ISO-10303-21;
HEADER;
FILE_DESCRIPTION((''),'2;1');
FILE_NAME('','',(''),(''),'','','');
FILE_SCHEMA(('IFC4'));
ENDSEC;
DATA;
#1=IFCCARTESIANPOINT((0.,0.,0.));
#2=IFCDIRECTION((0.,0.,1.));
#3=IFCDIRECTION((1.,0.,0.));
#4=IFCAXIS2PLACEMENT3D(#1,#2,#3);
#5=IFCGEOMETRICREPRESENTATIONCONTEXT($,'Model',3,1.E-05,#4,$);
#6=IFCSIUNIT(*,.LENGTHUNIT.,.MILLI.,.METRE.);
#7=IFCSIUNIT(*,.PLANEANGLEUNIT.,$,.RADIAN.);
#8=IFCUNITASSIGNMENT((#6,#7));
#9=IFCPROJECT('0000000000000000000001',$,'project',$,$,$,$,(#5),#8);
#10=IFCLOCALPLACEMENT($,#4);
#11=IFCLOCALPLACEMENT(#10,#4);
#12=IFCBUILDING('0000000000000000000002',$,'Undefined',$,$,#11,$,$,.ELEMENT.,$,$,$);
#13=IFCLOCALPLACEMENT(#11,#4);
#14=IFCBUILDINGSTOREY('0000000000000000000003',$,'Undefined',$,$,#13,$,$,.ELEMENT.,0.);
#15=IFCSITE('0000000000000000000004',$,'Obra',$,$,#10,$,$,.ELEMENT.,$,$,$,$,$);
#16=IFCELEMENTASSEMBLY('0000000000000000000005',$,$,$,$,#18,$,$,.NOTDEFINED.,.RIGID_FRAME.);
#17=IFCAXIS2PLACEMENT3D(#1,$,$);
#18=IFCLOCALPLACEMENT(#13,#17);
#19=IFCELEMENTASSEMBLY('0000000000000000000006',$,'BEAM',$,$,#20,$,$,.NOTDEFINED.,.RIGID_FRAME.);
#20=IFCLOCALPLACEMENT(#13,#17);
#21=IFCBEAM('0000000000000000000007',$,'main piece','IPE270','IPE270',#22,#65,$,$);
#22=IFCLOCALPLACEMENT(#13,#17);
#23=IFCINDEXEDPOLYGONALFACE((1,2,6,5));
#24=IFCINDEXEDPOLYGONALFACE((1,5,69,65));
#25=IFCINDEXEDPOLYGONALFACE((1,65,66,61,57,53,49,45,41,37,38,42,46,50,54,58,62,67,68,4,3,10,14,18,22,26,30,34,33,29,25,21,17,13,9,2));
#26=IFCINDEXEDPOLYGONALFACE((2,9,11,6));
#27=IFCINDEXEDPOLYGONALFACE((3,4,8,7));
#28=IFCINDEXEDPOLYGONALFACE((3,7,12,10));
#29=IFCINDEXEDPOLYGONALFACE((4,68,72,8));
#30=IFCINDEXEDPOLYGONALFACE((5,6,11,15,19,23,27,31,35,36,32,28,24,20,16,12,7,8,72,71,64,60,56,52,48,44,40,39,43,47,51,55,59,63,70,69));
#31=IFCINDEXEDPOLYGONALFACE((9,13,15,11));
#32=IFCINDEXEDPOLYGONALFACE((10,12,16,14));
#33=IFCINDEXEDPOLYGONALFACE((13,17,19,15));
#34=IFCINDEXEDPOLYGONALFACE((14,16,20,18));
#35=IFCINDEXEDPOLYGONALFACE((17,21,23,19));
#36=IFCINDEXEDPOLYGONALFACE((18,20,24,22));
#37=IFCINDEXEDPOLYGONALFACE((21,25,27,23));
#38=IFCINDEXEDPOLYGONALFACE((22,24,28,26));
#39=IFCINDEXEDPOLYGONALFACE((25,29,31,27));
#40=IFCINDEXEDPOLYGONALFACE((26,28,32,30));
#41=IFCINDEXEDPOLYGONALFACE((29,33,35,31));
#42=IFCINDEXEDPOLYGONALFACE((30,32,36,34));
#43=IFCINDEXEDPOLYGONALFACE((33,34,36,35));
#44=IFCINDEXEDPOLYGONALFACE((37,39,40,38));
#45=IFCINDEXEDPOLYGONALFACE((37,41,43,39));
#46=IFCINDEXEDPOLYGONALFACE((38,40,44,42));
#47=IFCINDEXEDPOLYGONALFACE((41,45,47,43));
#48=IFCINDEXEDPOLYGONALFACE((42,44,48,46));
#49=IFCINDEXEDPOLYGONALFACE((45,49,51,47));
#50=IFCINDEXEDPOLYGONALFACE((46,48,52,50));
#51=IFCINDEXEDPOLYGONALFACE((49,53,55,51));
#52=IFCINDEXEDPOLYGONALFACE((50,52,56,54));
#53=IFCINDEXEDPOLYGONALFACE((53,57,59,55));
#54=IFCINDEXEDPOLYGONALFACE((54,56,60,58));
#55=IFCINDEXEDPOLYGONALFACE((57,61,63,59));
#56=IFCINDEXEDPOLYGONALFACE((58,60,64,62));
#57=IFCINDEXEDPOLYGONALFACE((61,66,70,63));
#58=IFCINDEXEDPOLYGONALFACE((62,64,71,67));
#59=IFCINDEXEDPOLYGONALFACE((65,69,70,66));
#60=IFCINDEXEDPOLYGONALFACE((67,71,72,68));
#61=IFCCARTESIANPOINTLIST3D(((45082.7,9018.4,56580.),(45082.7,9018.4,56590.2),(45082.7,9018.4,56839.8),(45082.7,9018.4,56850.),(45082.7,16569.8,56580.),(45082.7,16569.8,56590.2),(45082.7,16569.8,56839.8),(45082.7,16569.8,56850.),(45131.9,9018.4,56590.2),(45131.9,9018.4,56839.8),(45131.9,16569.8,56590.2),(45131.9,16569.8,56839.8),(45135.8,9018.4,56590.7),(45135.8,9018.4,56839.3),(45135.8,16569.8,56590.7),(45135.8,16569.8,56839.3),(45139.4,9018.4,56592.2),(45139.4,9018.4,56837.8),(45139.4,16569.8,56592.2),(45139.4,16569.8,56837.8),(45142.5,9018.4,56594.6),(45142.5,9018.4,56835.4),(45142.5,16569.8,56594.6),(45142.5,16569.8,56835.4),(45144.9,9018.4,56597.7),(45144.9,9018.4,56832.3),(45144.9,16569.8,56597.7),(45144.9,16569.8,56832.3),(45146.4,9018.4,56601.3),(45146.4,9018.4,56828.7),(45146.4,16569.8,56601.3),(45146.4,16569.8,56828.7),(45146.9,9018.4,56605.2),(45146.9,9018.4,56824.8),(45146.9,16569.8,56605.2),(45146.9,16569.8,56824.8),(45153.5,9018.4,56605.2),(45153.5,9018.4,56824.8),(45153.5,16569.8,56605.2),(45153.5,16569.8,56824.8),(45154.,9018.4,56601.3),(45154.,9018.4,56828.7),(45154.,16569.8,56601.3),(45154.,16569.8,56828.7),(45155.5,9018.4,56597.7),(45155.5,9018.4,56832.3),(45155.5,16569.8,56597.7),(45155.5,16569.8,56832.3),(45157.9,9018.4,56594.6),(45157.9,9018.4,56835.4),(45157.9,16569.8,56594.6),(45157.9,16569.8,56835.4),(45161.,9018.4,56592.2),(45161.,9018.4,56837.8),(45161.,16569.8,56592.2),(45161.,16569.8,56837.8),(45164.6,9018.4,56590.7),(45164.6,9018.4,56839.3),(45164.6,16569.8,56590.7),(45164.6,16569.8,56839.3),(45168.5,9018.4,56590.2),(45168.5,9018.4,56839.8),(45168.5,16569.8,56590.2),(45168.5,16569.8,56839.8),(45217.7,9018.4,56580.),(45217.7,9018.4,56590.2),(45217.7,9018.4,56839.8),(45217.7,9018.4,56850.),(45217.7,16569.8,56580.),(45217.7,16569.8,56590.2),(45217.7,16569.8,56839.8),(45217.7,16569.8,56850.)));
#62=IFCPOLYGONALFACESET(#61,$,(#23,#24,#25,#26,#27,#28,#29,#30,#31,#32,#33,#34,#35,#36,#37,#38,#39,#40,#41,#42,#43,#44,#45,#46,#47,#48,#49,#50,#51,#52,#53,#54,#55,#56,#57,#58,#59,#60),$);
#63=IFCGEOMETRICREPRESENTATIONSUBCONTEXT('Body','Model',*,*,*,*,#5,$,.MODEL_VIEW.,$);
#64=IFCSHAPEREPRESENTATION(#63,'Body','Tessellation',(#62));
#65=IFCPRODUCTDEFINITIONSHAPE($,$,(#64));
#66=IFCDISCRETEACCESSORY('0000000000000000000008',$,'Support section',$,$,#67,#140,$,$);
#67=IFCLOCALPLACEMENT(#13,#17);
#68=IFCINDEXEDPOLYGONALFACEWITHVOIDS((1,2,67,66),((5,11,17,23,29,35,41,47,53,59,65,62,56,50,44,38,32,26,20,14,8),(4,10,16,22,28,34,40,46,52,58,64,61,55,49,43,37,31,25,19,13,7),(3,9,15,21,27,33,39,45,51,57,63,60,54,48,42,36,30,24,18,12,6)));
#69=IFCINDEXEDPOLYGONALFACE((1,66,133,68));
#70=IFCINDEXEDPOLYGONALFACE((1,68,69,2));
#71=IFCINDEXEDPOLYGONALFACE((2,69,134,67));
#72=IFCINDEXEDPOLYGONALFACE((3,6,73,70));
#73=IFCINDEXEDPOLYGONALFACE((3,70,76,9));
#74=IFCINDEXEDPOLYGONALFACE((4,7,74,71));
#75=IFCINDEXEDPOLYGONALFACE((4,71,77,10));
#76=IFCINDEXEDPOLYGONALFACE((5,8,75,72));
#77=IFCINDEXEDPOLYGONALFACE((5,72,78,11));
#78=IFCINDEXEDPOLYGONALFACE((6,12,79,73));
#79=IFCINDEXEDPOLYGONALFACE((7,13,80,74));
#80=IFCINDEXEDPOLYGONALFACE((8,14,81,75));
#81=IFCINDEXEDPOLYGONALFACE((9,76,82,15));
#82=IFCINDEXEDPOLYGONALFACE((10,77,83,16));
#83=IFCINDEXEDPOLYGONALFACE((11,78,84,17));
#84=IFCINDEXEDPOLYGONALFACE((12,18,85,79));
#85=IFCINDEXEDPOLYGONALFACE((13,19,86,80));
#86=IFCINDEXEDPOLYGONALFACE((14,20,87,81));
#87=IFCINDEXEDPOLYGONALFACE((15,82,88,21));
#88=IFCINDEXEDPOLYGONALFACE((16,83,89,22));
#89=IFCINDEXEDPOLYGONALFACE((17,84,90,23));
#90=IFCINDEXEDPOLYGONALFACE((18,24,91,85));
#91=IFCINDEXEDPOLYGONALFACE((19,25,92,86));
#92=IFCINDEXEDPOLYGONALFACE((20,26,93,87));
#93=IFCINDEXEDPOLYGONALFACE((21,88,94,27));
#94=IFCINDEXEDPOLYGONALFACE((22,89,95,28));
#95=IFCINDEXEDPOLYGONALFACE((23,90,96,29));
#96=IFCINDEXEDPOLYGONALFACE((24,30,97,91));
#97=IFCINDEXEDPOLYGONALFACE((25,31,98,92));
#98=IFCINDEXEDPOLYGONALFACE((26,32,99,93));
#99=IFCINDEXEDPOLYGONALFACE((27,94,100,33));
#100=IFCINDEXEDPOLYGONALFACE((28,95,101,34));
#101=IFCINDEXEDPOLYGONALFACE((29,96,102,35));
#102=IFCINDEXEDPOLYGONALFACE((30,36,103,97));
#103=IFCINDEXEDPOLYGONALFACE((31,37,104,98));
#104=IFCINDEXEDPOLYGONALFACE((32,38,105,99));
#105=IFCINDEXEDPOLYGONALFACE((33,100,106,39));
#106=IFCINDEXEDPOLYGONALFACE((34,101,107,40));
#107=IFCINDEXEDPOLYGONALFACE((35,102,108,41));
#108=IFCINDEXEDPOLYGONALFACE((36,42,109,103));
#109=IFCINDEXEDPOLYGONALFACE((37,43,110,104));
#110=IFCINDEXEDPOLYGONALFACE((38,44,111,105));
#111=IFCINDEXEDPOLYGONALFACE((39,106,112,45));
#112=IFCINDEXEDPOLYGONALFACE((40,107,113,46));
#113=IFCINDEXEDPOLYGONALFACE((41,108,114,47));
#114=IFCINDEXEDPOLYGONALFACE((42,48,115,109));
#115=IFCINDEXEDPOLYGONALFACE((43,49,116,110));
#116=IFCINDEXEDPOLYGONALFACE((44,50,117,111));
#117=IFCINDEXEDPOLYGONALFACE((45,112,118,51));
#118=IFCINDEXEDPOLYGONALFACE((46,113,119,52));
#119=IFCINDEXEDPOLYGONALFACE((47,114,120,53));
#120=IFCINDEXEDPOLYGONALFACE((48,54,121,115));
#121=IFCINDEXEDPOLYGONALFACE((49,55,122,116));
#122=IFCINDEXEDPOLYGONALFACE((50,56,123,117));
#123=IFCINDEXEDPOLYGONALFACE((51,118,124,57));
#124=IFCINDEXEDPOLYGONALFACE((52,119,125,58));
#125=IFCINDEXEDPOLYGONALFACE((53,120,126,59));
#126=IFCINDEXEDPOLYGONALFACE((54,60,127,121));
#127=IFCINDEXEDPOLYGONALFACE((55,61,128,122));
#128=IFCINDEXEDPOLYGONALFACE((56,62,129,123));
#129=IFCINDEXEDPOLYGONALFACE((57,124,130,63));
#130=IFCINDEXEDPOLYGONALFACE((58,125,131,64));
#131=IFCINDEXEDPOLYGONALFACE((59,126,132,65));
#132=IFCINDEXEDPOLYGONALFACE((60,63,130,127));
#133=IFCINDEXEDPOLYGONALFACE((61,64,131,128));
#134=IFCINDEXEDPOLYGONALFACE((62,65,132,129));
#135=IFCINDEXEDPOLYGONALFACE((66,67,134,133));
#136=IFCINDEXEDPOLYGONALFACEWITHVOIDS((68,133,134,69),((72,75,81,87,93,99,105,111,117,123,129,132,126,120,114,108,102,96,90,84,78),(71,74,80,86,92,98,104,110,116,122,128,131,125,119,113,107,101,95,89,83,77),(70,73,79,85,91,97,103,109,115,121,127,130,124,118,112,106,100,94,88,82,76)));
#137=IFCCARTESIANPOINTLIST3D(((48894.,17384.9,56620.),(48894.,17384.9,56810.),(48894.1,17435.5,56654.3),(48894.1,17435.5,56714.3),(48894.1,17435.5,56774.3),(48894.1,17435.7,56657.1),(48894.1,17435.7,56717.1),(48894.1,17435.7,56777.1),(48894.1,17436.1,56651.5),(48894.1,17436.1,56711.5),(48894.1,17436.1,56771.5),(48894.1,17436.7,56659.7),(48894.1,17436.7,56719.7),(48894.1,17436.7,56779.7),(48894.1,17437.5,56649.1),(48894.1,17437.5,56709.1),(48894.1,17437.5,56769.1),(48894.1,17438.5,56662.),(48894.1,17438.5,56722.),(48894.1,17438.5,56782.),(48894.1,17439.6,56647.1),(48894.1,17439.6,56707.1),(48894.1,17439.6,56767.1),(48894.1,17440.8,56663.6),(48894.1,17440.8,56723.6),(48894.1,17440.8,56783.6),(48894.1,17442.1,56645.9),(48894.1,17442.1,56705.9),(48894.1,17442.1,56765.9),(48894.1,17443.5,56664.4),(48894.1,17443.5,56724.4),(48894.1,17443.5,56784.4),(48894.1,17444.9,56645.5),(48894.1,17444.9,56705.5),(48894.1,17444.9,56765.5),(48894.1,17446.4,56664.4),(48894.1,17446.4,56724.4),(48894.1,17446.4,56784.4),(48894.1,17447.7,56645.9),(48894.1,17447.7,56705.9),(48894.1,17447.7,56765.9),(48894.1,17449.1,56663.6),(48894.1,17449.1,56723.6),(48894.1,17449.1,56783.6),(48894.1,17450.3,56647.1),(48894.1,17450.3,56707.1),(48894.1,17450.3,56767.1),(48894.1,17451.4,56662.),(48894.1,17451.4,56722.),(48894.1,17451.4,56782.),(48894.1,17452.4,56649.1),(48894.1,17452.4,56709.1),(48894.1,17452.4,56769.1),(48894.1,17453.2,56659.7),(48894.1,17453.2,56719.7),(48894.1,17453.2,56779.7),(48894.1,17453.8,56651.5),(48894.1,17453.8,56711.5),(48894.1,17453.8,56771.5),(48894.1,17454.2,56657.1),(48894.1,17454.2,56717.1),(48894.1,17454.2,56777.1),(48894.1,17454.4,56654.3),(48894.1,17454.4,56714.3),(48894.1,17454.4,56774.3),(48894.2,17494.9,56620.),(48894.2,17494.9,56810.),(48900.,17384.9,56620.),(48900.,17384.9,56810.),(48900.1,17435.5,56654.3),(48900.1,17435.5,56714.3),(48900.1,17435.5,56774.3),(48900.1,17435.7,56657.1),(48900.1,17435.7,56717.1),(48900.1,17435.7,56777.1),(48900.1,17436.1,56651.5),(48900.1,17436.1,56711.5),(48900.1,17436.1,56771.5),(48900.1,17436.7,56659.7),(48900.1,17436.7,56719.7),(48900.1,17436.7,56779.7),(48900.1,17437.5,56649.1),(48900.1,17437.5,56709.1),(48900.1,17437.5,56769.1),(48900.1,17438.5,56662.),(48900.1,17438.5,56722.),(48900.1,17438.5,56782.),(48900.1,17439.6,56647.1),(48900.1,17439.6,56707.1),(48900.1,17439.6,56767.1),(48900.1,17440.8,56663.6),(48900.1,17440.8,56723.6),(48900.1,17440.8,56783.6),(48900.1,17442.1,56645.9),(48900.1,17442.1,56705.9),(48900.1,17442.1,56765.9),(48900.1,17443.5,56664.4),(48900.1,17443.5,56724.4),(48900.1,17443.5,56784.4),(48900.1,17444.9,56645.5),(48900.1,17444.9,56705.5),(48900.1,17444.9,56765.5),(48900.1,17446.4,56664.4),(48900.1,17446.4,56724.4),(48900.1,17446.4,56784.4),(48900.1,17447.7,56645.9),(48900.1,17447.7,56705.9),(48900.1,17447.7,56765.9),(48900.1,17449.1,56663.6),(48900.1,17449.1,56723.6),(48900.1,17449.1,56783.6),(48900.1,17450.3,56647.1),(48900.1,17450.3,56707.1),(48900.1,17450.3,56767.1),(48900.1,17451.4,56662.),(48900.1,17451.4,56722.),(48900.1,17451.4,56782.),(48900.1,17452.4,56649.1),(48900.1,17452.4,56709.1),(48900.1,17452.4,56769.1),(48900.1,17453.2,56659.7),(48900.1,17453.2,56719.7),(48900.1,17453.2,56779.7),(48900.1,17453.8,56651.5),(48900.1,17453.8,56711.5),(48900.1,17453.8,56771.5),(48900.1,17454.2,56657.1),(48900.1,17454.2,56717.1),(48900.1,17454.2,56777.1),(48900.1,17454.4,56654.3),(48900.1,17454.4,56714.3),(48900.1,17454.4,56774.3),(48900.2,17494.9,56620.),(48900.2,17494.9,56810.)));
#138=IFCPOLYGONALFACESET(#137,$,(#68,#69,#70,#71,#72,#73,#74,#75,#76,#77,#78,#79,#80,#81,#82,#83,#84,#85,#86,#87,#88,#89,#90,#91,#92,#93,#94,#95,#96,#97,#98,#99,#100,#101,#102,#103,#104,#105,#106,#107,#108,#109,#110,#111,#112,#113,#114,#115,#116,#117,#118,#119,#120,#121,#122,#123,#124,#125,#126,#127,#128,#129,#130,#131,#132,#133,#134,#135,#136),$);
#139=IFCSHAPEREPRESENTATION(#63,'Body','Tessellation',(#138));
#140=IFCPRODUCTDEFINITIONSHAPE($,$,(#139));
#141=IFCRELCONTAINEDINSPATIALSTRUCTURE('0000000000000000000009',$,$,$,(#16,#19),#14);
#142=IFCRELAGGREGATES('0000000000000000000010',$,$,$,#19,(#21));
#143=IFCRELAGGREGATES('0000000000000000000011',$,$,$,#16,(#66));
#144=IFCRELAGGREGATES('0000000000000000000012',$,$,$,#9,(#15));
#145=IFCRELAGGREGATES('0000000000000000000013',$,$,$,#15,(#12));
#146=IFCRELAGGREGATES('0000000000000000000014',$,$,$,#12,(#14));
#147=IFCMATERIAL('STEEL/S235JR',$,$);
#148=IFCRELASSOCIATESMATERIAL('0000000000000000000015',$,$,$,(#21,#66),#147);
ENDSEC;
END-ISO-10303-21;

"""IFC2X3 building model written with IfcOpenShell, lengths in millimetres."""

from ifc_helpers import new_model, si_unit, frame, origin_with_axes, origin_2d_with_axis, place, context, subcontext, project, spatial, rectangle, circle, i_section, extrude, source, transform, mapped, material, element, aggregate, save


model = new_model("IFC2X3")

# Units and contexts
model_context = context("Model", 3, precision=1e-05, world=origin_with_axes())
body_context = subcontext(model_context, "Body", "Model", "MODEL_VIEW")
ifc_project = project(units=[si_unit("LENGTHUNIT", "METRE", prefix="MILLI"), si_unit("PLANEANGLEUNIT", "RADIAN")], contexts=[model_context])

# Site, building, storey
site_placement = place(None, origin_with_axes())
site = spatial("IfcSite", under=ifc_project, at=site_placement, Name="Obra", CompositionType="ELEMENT")
building_placement = place(site_placement, origin_with_axes())
building = spatial("IfcBuilding", under=site, at=building_placement, Name="Undefined", CompositionType="ELEMENT")
storey_placement = place(building_placement, origin_with_axes())
storey = spatial("IfcBuildingStorey", under=building, at=storey_placement, Name="Undefined", CompositionType="ELEMENT", Elevation=0.0)

# Element assembly
assembly_1_placement = place(storey_placement, origin_with_axes())
assembly_1 = element("IfcElementAssembly", 1, at=assembly_1_placement, inside=storey, AssemblyPlace="NOTDEFINED", PredefinedType="RIGID_FRAME")
ifc_material_1 = material(Name="STEEL/S235JR")

# Element assembly, beam
assembly_2_placement = place(storey_placement, origin_with_axes())
assembly_2 = element("IfcElementAssembly", 2, at=assembly_2_placement, inside=storey, Name="BEAM", AssemblyPlace="NOTDEFINED", PredefinedType="RIGID_FRAME")
beam_1_placement = place(assembly_2_placement, frame((45150.2, 16569.8, 56715.0), z_axis=(0.0, 0.0, 1.0), x_axis=(0.0, -1.0, 0.0)))
beam_1 = element("IfcBeam", 3, at=beam_1_placement, material=ifc_material_1, Name="main piece", Description="IPE270", ObjectType="IPE270", context=body_context, shape_type="SweptSolid", body=[
    extrude(i_section(OverallWidth=135.0, OverallDepth=270.0, WebThickness=6.6, FlangeThickness=10.2, FilletRadius=15.0, at=origin_2d_with_axis()), frame((7551.4, 0.0, 0.0), z_axis=(-1.0, 0.0, 0.0), x_axis=(0.0, -1.0, 0.0)), (0.0, 0.0, 1.0), 7551.4),
])
aggregate(assembly_2, [beam_1])

# Discrete accessory, opening
discrete_accessory_1_placement = place(assembly_1_placement, frame((48897.1, 17439.9, 56620.0), z_axis=(0.0, 0.0, 1.0), x_axis=(-0.001649, -0.999999, 0.0)))
discrete_accessory_1 = element("IfcDiscreteAccessory", 4, at=discrete_accessory_1_placement, material=ifc_material_1, Name="Support section", context=body_context, shape_type="SweptSolid", body=[
    extrude(rectangle(XDim=6.0, YDim=110.0, at=origin_2d_with_axis()), frame((0.0, 0.0, 190.0), z_axis=(0.0, 0.0, -1.0), x_axis=(0.0, 1.0, 0.0)), (0.0, 0.0, 1.0), 190.0),
])
shared_shape_1 = source(origin_with_axes(), body_context, "Body", "SweptSolid", [
    extrude(circle(Radius=9.5, at=origin_2d_with_axis()), frame((0.0, -9.2, 0.0), z_axis=(0.0, 1.0, 0.0), x_axis=(1.0, 0.0, 0.0)), (0.0, 0.0, 1.0), 6.2),
])
opening_1_placement = place(assembly_1_placement, frame((48890.9, 17395.0, 56835.0), z_axis=(0.001649, 0.999999, 0.0), x_axis=(0.0, 0.0, -1.0)))
element("IfcOpeningElement", 5, at=opening_1_placement, cuts=discrete_accessory_1, ObjectType="Opening", context=body_context, shape_type="MappedRepresentation", body=[
    mapped(shared_shape_1, transform((60.0, 0.0, 50.0))),
    mapped(shared_shape_1, transform((120.0, 0.0, 50.0))),
    mapped(shared_shape_1, transform((180.0, 0.0, 50.0))),
])
aggregate(assembly_1, [discrete_accessory_1])

save(model, "model.ifc")
